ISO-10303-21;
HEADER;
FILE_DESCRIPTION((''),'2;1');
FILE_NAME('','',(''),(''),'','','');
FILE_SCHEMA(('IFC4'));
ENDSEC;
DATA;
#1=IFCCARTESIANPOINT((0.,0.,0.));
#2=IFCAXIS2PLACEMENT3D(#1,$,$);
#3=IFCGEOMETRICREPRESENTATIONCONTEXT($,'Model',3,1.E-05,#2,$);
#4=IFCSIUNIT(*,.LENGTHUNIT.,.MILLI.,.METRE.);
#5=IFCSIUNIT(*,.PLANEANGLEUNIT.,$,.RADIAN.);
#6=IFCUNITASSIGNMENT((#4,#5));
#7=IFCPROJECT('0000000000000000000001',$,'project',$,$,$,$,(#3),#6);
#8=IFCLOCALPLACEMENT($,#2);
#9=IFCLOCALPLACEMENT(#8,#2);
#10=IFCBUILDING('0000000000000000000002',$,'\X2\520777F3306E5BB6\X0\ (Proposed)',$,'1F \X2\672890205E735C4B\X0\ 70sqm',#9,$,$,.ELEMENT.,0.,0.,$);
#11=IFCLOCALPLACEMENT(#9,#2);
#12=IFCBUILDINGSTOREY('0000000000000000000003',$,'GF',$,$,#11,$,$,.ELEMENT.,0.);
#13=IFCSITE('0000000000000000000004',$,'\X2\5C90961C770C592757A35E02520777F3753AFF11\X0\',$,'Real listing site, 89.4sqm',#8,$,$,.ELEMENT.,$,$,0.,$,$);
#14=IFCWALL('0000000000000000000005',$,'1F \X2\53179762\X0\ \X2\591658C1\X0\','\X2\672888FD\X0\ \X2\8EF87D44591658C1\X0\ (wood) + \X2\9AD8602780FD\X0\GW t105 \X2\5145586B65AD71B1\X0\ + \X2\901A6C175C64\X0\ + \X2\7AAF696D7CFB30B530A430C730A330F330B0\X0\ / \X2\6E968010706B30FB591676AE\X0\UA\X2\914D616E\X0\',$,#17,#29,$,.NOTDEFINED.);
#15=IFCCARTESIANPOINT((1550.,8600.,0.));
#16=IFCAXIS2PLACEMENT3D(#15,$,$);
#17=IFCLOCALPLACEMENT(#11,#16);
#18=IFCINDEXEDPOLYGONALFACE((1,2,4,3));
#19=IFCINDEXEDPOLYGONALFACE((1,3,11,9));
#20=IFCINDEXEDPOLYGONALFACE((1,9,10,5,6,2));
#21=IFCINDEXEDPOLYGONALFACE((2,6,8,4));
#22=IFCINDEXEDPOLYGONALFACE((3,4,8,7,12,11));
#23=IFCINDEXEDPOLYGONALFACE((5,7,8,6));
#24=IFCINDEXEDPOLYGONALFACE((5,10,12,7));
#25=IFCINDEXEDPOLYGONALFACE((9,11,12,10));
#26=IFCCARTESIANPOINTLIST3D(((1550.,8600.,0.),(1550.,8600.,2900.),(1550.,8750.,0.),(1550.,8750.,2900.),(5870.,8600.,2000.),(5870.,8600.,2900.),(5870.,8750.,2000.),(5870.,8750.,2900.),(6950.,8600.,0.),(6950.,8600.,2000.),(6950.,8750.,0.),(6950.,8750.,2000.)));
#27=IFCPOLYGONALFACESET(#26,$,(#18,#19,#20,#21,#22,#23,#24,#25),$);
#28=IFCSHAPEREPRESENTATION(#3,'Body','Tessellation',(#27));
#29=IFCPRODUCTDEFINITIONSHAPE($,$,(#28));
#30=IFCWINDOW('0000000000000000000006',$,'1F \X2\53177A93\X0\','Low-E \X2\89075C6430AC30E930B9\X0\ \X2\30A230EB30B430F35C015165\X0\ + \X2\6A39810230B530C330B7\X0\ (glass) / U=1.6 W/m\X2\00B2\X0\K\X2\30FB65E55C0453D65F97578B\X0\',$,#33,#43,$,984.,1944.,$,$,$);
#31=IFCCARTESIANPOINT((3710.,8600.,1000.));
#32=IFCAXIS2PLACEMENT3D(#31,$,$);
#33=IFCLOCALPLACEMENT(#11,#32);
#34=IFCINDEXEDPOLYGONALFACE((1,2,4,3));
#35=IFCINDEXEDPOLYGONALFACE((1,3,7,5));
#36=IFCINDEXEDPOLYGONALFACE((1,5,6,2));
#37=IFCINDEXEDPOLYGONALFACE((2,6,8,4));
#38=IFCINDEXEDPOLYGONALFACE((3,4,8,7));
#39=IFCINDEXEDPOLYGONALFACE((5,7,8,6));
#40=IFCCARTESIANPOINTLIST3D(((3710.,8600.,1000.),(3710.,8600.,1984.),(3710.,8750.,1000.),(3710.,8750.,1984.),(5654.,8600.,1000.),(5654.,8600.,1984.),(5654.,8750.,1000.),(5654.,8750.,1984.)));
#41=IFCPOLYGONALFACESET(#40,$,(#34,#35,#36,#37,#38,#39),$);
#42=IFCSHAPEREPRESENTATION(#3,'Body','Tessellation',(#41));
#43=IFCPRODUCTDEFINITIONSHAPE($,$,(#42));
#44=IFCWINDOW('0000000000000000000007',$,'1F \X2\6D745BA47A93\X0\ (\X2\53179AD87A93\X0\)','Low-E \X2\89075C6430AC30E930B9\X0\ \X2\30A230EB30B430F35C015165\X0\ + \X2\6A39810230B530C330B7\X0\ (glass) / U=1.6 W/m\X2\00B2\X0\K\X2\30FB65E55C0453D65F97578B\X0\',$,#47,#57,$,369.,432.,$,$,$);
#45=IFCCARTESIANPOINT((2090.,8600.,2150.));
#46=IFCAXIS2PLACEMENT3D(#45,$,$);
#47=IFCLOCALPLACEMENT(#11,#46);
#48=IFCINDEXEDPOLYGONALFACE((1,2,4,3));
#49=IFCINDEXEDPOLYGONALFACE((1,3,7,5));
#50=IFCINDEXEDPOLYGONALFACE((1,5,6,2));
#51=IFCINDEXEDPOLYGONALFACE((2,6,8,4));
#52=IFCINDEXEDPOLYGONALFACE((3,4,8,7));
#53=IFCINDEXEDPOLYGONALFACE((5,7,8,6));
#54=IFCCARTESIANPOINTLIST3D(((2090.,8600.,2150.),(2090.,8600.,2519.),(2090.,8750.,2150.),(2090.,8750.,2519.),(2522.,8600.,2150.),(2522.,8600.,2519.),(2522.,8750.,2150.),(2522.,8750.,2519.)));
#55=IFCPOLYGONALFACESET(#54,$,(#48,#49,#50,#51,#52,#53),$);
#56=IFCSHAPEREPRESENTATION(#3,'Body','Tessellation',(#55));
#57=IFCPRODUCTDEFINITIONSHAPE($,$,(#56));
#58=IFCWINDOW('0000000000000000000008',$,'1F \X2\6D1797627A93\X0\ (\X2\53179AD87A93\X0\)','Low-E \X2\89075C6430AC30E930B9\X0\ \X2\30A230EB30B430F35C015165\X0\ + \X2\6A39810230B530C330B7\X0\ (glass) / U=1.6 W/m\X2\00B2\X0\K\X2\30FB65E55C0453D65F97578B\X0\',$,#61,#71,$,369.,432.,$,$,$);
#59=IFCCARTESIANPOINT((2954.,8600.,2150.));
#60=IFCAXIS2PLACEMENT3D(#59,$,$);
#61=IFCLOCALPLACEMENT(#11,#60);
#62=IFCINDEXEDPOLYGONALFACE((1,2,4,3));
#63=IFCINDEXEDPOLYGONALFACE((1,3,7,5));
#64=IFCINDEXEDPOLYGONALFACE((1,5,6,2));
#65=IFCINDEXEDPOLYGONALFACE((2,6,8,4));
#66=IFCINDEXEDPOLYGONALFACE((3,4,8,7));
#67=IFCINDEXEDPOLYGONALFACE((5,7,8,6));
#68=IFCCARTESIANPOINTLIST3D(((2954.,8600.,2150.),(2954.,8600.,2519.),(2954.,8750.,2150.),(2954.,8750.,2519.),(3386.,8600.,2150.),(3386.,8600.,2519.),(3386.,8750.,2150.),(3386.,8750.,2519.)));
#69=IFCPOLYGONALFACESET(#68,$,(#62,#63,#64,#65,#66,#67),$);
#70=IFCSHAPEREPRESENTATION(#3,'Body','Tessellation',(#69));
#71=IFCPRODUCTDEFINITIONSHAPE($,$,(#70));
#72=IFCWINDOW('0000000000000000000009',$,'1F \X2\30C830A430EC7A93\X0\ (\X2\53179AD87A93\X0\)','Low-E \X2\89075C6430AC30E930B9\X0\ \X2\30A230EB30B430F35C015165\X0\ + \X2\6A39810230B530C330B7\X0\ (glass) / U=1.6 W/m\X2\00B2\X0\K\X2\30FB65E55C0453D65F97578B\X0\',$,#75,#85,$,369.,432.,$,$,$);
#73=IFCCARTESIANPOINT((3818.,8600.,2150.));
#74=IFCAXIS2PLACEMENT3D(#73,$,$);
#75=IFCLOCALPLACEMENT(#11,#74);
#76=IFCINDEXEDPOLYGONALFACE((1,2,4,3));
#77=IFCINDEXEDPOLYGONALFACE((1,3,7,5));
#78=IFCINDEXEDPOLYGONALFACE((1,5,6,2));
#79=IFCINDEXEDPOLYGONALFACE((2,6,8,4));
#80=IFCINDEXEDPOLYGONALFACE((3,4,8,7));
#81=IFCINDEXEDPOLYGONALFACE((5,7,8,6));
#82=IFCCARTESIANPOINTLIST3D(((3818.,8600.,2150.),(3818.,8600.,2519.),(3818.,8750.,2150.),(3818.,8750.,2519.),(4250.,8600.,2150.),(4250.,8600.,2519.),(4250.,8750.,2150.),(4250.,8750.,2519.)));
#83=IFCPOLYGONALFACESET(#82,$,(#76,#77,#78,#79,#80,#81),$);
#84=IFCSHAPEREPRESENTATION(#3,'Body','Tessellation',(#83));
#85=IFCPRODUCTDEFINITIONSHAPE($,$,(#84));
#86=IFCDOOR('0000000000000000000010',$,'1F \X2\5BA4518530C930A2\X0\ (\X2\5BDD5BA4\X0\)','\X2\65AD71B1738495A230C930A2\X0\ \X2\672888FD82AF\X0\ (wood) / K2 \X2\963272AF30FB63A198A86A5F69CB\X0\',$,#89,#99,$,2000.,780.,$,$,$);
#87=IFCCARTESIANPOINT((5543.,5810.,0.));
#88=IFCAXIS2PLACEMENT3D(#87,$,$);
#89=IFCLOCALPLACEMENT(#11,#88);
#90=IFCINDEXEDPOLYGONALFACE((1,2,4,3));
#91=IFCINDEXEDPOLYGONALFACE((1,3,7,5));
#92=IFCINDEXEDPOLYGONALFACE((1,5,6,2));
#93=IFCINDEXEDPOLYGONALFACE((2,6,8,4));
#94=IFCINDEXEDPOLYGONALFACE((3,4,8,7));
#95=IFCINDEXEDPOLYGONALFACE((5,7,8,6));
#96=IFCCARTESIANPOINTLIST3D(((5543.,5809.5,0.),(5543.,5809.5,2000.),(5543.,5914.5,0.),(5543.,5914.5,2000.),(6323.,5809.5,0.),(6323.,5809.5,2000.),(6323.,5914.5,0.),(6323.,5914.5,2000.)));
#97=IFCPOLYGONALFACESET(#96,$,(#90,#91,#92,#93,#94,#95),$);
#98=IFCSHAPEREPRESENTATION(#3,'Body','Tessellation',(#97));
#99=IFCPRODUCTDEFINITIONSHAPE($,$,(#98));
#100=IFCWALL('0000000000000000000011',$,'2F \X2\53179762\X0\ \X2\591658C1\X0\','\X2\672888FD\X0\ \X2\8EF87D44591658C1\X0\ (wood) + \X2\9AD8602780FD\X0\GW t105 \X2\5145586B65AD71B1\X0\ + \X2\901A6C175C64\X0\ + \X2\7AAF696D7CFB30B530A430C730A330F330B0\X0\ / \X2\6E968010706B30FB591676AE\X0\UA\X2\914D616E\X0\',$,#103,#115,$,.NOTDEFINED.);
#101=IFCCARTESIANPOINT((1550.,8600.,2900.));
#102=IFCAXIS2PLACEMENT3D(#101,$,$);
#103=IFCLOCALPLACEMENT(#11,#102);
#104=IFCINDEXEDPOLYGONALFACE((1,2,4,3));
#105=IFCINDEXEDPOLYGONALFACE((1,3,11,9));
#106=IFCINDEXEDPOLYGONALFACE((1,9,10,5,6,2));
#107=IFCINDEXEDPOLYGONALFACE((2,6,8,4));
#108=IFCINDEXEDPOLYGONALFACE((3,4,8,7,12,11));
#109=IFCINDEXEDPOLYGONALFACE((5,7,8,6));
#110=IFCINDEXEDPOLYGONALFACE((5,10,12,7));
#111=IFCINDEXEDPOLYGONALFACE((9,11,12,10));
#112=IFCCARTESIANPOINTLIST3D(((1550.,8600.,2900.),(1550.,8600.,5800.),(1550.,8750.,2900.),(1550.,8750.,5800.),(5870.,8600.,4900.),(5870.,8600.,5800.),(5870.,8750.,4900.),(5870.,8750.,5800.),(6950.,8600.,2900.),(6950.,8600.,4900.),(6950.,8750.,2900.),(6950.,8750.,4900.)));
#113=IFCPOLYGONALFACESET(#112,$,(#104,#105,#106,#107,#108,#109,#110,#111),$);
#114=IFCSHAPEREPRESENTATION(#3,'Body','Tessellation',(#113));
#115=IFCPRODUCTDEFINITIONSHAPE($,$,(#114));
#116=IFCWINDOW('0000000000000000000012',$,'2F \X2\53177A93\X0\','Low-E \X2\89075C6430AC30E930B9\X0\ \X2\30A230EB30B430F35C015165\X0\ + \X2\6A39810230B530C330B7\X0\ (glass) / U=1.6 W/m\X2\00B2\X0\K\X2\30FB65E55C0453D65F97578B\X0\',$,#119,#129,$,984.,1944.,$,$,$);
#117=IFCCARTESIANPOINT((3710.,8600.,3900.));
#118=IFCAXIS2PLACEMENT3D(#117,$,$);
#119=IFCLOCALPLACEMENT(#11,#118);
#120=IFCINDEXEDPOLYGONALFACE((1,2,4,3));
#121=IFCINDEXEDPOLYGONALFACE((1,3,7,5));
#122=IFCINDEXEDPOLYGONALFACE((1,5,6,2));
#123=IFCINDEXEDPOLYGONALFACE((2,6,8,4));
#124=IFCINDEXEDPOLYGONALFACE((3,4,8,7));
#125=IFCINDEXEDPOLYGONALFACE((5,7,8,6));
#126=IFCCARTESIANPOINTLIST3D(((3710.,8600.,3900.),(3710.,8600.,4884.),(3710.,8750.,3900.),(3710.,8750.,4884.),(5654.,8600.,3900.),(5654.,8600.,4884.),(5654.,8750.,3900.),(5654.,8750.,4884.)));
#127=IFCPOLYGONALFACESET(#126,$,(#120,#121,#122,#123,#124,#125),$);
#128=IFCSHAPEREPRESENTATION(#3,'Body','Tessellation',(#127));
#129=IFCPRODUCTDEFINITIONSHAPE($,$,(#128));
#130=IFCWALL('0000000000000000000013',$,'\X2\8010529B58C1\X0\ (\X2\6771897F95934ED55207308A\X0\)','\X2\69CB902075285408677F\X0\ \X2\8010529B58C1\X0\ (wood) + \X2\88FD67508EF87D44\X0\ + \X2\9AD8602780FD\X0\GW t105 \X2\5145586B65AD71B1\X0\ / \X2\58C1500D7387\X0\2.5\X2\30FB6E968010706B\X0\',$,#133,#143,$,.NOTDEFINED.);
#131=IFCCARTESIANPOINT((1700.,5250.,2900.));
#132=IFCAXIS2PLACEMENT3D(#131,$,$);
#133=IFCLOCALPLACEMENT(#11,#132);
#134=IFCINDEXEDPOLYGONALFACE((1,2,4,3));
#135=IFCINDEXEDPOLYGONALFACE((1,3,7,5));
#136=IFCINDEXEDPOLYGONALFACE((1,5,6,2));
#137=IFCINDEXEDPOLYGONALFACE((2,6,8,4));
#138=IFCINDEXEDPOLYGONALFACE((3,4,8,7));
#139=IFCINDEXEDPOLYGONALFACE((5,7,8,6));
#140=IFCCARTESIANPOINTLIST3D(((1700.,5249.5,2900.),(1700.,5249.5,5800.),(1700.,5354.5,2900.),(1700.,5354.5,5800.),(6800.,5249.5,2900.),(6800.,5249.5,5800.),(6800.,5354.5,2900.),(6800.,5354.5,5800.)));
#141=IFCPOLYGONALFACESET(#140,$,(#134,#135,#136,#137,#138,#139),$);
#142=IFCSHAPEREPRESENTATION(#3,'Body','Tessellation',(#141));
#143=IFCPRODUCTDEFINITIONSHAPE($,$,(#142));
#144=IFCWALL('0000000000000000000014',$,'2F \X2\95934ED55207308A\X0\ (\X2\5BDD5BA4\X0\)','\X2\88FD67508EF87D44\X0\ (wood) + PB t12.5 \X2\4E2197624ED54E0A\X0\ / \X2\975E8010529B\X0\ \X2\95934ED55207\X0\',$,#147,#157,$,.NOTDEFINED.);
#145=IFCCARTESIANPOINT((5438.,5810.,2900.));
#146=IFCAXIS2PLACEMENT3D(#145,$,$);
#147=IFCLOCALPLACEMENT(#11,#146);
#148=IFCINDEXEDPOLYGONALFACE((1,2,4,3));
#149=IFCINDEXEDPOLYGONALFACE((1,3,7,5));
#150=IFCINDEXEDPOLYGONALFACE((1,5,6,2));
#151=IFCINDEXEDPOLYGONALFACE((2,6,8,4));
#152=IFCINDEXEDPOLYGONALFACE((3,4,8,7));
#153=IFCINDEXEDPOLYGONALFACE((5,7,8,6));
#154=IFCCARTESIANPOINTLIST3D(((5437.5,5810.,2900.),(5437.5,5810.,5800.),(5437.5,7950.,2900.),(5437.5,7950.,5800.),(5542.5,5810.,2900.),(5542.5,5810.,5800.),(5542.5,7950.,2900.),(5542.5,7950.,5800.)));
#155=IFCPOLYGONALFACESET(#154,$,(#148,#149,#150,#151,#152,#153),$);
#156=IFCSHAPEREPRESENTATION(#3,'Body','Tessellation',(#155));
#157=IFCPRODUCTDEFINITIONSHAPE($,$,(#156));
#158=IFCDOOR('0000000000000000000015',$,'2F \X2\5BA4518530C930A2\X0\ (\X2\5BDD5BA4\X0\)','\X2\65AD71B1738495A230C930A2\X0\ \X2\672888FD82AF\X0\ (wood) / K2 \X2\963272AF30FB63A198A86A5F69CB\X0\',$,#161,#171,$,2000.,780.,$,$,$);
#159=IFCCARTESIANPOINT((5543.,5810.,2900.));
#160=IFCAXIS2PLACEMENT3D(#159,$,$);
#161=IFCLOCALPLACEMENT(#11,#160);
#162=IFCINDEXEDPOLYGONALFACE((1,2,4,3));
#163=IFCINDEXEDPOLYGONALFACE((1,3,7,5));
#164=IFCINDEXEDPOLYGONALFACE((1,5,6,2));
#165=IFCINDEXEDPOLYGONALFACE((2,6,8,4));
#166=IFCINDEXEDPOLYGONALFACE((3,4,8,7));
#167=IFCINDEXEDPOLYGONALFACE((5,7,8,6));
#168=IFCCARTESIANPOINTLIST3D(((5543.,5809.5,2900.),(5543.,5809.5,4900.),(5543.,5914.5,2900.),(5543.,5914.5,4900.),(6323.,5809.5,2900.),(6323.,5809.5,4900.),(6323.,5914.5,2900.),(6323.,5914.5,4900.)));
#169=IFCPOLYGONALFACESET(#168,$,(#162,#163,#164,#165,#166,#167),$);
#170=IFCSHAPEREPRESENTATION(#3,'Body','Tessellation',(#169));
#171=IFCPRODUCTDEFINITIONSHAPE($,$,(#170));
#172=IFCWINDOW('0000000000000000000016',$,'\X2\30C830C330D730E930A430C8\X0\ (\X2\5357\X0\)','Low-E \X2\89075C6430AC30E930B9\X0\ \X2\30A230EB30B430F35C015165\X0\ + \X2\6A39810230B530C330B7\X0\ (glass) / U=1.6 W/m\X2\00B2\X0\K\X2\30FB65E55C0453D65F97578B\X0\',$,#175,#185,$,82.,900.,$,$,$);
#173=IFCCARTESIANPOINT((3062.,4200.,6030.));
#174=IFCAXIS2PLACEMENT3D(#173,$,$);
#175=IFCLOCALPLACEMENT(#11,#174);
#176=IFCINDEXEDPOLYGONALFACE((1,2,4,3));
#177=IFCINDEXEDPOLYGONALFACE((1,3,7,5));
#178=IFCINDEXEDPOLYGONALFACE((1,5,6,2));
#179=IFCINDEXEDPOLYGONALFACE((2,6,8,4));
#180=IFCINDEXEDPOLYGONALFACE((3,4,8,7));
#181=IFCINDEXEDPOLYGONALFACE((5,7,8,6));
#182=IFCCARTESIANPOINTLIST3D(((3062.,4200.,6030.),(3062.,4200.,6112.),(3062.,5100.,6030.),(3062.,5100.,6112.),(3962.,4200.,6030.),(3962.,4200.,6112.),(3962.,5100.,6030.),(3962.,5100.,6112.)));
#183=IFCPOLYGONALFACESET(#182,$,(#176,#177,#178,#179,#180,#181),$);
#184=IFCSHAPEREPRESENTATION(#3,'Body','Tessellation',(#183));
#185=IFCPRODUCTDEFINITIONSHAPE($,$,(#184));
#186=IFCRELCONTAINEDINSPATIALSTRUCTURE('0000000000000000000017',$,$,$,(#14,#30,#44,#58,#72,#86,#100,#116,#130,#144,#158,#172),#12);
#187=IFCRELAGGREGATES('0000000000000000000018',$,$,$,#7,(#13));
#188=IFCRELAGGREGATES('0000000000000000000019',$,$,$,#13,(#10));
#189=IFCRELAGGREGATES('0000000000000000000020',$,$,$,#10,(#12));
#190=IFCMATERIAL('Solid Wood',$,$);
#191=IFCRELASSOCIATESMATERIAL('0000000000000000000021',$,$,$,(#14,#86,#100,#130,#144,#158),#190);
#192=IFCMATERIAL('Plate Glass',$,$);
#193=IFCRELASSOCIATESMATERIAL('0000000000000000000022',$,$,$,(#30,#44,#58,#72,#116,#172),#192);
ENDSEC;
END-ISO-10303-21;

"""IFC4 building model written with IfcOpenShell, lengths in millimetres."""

from ifc_helpers import new_model, si_unit, frame, frame_2d, origin, place, context, project, spatial, rectangle, extrude, material, element, fill, save


model = new_model("IFC4")

# Units and contexts
model_context = context("Model", 3, precision=1e-05, world=origin())
ifc_project = project(units=[si_unit("LENGTHUNIT", "METRE", prefix="MILLI"), si_unit("PLANEANGLEUNIT", "RADIAN")], contexts=[model_context])

# Site, building, storey
site_placement = place(None, origin())
site = spatial("IfcSite", under=ifc_project, at=site_placement, Name="岐阜県大垣市切石町１", ObjectType="Real listing site, 89.4sqm", CompositionType="ELEMENT", RefElevation=0.0)
building_placement = place(site_placement, origin())
building = spatial("IfcBuilding", under=site, at=building_placement, Name="切石の家 (Proposed)", ObjectType="1F 木造平屋 70sqm", CompositionType="ELEMENT", ElevationOfRefHeight=0.0, ElevationOfTerrain=0.0)
storey_placement = place(building_placement, origin())
storey = spatial("IfcBuildingStorey", under=building, at=storey_placement, Name="GF", CompositionType="ELEMENT", Elevation=0.0)

# Wall, openings, windows
ifc_material_1 = material(Name="Solid Wood")
wall_1_placement = place(storey_placement, frame((1550.0, 8600.0, 0.0)))
wall_1 = element("IfcWall", 1, at=wall_1_placement, inside=storey, material=ifc_material_1, Name="1F 北面 外壁", Description="木製 軸組外壁 (wood) + 高性能GW t105 充填断熱 + 通気層 + 窯業系サイディング / 準耐火・外皮UA配慮", PredefinedType="NOTDEFINED", context=model_context, shape_type="SweptSolid", body=[
    extrude(rectangle(XDim=5400.0, YDim=150.0, at=frame_2d((2700.0, 75.0))), frame((1550.0, 8600.0, 0.0)), (0.0, 0.0, 1.0), 2900.0),
])
opening_1_placement = place(storey_placement, frame((3710.0, 8600.0, 1000.0)))
opening_1 = element("IfcOpeningElement", 2, at=opening_1_placement, cuts=wall_1, PredefinedType="NOTDEFINED", context=model_context, shape_type="SweptSolid", body=[
    extrude(rectangle(XDim=1944.0, YDim=150.0, at=frame_2d((972.0, 75.0))), frame((3710.0, 8600.0, 1000.0)), (0.0, 0.0, 1.0), 984.0),
])
opening_2_placement = place(storey_placement, frame((2090.0, 8600.0, 2150.0)))
opening_2 = element("IfcOpeningElement", 3, at=opening_2_placement, cuts=wall_1, PredefinedType="NOTDEFINED", context=model_context, shape_type="SweptSolid", body=[
    extrude(rectangle(XDim=432.0, YDim=150.0, at=frame_2d((216.0, 75.0))), frame((2090.0, 8600.0, 2150.0)), (0.0, 0.0, 1.0), 369.0),
])
opening_3_placement = place(storey_placement, frame((2954.0, 8600.0, 2150.0)))
opening_3 = element("IfcOpeningElement", 4, at=opening_3_placement, cuts=wall_1, PredefinedType="NOTDEFINED", context=model_context, shape_type="SweptSolid", body=[
    extrude(rectangle(XDim=432.0, YDim=150.0, at=frame_2d((216.0, 75.0))), frame((2954.0, 8600.0, 2150.0)), (0.0, 0.0, 1.0), 369.0),
])
opening_4_placement = place(storey_placement, frame((3818.0, 8600.0, 2150.0)))
opening_4 = element("IfcOpeningElement", 5, at=opening_4_placement, cuts=wall_1, PredefinedType="NOTDEFINED", context=model_context, shape_type="SweptSolid", body=[
    extrude(rectangle(XDim=432.0, YDim=150.0, at=frame_2d((216.0, 75.0))), frame((3818.0, 8600.0, 2150.0)), (0.0, 0.0, 1.0), 369.0),
])
ifc_material_2 = material(Name="Plate Glass")
window_1_placement = place(storey_placement, frame((3710.0, 8600.0, 1000.0)))
window_1 = element("IfcWindow", 6, at=window_1_placement, inside=storey, material=ifc_material_2, Name="1F 北窓", Description="Low-E 複層ガラス アルゴン封入 + 樹脂サッシ (glass) / U=1.6 W/m²K・日射取得型", OverallHeight=984.0, OverallWidth=1944.0, context=model_context, shape_type="SweptSolid", body=[
    extrude(rectangle(XDim=1944.0, YDim=150.0, at=frame_2d((972.0, 75.0))), frame((3710.0, 8600.0, 1000.0)), (0.0, 0.0, 1.0), 984.0),
])
fill(opening_1, window_1)
window_2_placement = place(storey_placement, frame((2090.0, 8600.0, 2150.0)))
window_2 = element("IfcWindow", 7, at=window_2_placement, inside=storey, material=ifc_material_2, Name="1F 浴室窓 (北高窓)", Description="Low-E 複層ガラス アルゴン封入 + 樹脂サッシ (glass) / U=1.6 W/m²K・日射取得型", OverallHeight=369.0, OverallWidth=432.0, context=model_context, shape_type="SweptSolid", body=[
    extrude(rectangle(XDim=432.0, YDim=150.0, at=frame_2d((216.0, 75.0))), frame((2090.0, 8600.0, 2150.0)), (0.0, 0.0, 1.0), 369.0),
])
fill(opening_2, window_2)
window_3_placement = place(storey_placement, frame((2954.0, 8600.0, 2150.0)))
window_3 = element("IfcWindow", 8, at=window_3_placement, inside=storey, material=ifc_material_2, Name="1F 洗面窓 (北高窓)", Description="Low-E 複層ガラス アルゴン封入 + 樹脂サッシ (glass) / U=1.6 W/m²K・日射取得型", OverallHeight=369.0, OverallWidth=432.0, context=model_context, shape_type="SweptSolid", body=[
    extrude(rectangle(XDim=432.0, YDim=150.0, at=frame_2d((216.0, 75.0))), frame((2954.0, 8600.0, 2150.0)), (0.0, 0.0, 1.0), 369.0),
])
fill(opening_3, window_3)
window_4_placement = place(storey_placement, frame((3818.0, 8600.0, 2150.0)))
window_4 = element("IfcWindow", 9, at=window_4_placement, inside=storey, material=ifc_material_2, Name="1F トイレ窓 (北高窓)", Description="Low-E 複層ガラス アルゴン封入 + 樹脂サッシ (glass) / U=1.6 W/m²K・日射取得型", OverallHeight=369.0, OverallWidth=432.0, context=model_context, shape_type="SweptSolid", body=[
    extrude(rectangle(XDim=432.0, YDim=150.0, at=frame_2d((216.0, 75.0))), frame((3818.0, 8600.0, 2150.0)), (0.0, 0.0, 1.0), 369.0),
])
fill(opening_4, window_4)

# Door
door_1_placement = place(storey_placement, frame((5543.0, 5810.0, 0.0)))
element("IfcDoor", 10, at=door_1_placement, inside=storey, material=ifc_material_1, Name="1F 室内ドア (寝室)", Description="断熱玄関ドア 木製芯 (wood) / K2 防犯・採風機構", OverallHeight=2000.0, OverallWidth=780.0, context=model_context, shape_type="SweptSolid", body=[
    extrude(rectangle(XDim=780.0, YDim=105.0, at=frame_2d((390.0, 52.0))), frame((5543.0, 5810.0, 0.0)), (0.0, 0.0, 1.0), 2000.0),
])

# Wall, opening, window
wall_2_placement = place(storey_placement, frame((1550.0, 8600.0, 2900.0)))
wall_2 = element("IfcWall", 11, at=wall_2_placement, inside=storey, material=ifc_material_1, Name="2F 北面 外壁", Description="木製 軸組外壁 (wood) + 高性能GW t105 充填断熱 + 通気層 + 窯業系サイディング / 準耐火・外皮UA配慮", PredefinedType="NOTDEFINED", context=model_context, shape_type="SweptSolid", body=[
    extrude(rectangle(XDim=5400.0, YDim=150.0, at=frame_2d((2700.0, 75.0))), frame((1550.0, 8600.0, 2900.0)), (0.0, 0.0, 1.0), 2900.0),
])
opening_5_placement = place(storey_placement, frame((3710.0, 8600.0, 3900.0)))
opening_5 = element("IfcOpeningElement", 12, at=opening_5_placement, cuts=wall_2, PredefinedType="NOTDEFINED", context=model_context, shape_type="SweptSolid", body=[
    extrude(rectangle(XDim=1944.0, YDim=150.0, at=frame_2d((972.0, 75.0))), frame((3710.0, 8600.0, 3900.0)), (0.0, 0.0, 1.0), 984.0),
])
window_5_placement = place(storey_placement, frame((3710.0, 8600.0, 3900.0)))
window_5 = element("IfcWindow", 13, at=window_5_placement, inside=storey, material=ifc_material_2, Name="2F 北窓", Description="Low-E 複層ガラス アルゴン封入 + 樹脂サッシ (glass) / U=1.6 W/m²K・日射取得型", OverallHeight=984.0, OverallWidth=1944.0, context=model_context, shape_type="SweptSolid", body=[
    extrude(rectangle(XDim=1944.0, YDim=150.0, at=frame_2d((972.0, 75.0))), frame((3710.0, 8600.0, 3900.0)), (0.0, 0.0, 1.0), 984.0),
])
fill(opening_5, window_5)

# Walls
wall_3_placement = place(storey_placement, frame((1700.0, 5250.0, 2900.0)))
element("IfcWall", 14, at=wall_3_placement, inside=storey, material=ifc_material_1, Name="耐力壁 (東西間仕切り)", Description="構造用合板 耐力壁 (wood) + 製材軸組 + 高性能GW t105 充填断熱 / 壁倍率2.5・準耐火", PredefinedType="NOTDEFINED", context=model_context, shape_type="SweptSolid", body=[
    extrude(rectangle(XDim=5100.0, YDim=105.0, at=frame_2d((2550.0, 52.0))), frame((1700.0, 5250.0, 2900.0)), (0.0, 0.0, 1.0), 2900.0),
])
wall_4_placement = place(storey_placement, frame((5438.0, 5810.0, 2900.0)))
element("IfcWall", 15, at=wall_4_placement, inside=storey, material=ifc_material_1, Name="2F 間仕切り (寝室)", Description="製材軸組 (wood) + PB t12.5 両面仕上 / 非耐力 間仕切", PredefinedType="NOTDEFINED", context=model_context, shape_type="SweptSolid", body=[
    extrude(rectangle(XDim=105.0, YDim=2140.0, at=frame_2d((52.0, 1070.0))), frame((5438.0, 5810.0, 2900.0)), (0.0, 0.0, 1.0), 2900.0),
])

# Door
door_2_placement = place(storey_placement, frame((5543.0, 5810.0, 2900.0)))
element("IfcDoor", 16, at=door_2_placement, inside=storey, material=ifc_material_1, Name="2F 室内ドア (寝室)", Description="断熱玄関ドア 木製芯 (wood) / K2 防犯・採風機構", OverallHeight=2000.0, OverallWidth=780.0, context=model_context, shape_type="SweptSolid", body=[
    extrude(rectangle(XDim=780.0, YDim=105.0, at=frame_2d((390.0, 52.0))), frame((5543.0, 5810.0, 2900.0)), (0.0, 0.0, 1.0), 2000.0),
])

# Window
window_6_placement = place(storey_placement, frame((3062.0, 4200.0, 6030.0)))
element("IfcWindow", 17, at=window_6_placement, inside=storey, material=ifc_material_2, Name="トップライト (南)", Description="Low-E 複層ガラス アルゴン封入 + 樹脂サッシ (glass) / U=1.6 W/m²K・日射取得型", OverallHeight=82.0, OverallWidth=900.0, context=model_context, shape_type="SweptSolid", body=[
    extrude(rectangle(XDim=900.0, YDim=900.0, at=frame_2d((450.0, 450.0))), frame((3062.0, 4200.0, 6030.0)), (0.0, 0.0, 1.0), 82.0),
])

save(model, "model.ifc")
